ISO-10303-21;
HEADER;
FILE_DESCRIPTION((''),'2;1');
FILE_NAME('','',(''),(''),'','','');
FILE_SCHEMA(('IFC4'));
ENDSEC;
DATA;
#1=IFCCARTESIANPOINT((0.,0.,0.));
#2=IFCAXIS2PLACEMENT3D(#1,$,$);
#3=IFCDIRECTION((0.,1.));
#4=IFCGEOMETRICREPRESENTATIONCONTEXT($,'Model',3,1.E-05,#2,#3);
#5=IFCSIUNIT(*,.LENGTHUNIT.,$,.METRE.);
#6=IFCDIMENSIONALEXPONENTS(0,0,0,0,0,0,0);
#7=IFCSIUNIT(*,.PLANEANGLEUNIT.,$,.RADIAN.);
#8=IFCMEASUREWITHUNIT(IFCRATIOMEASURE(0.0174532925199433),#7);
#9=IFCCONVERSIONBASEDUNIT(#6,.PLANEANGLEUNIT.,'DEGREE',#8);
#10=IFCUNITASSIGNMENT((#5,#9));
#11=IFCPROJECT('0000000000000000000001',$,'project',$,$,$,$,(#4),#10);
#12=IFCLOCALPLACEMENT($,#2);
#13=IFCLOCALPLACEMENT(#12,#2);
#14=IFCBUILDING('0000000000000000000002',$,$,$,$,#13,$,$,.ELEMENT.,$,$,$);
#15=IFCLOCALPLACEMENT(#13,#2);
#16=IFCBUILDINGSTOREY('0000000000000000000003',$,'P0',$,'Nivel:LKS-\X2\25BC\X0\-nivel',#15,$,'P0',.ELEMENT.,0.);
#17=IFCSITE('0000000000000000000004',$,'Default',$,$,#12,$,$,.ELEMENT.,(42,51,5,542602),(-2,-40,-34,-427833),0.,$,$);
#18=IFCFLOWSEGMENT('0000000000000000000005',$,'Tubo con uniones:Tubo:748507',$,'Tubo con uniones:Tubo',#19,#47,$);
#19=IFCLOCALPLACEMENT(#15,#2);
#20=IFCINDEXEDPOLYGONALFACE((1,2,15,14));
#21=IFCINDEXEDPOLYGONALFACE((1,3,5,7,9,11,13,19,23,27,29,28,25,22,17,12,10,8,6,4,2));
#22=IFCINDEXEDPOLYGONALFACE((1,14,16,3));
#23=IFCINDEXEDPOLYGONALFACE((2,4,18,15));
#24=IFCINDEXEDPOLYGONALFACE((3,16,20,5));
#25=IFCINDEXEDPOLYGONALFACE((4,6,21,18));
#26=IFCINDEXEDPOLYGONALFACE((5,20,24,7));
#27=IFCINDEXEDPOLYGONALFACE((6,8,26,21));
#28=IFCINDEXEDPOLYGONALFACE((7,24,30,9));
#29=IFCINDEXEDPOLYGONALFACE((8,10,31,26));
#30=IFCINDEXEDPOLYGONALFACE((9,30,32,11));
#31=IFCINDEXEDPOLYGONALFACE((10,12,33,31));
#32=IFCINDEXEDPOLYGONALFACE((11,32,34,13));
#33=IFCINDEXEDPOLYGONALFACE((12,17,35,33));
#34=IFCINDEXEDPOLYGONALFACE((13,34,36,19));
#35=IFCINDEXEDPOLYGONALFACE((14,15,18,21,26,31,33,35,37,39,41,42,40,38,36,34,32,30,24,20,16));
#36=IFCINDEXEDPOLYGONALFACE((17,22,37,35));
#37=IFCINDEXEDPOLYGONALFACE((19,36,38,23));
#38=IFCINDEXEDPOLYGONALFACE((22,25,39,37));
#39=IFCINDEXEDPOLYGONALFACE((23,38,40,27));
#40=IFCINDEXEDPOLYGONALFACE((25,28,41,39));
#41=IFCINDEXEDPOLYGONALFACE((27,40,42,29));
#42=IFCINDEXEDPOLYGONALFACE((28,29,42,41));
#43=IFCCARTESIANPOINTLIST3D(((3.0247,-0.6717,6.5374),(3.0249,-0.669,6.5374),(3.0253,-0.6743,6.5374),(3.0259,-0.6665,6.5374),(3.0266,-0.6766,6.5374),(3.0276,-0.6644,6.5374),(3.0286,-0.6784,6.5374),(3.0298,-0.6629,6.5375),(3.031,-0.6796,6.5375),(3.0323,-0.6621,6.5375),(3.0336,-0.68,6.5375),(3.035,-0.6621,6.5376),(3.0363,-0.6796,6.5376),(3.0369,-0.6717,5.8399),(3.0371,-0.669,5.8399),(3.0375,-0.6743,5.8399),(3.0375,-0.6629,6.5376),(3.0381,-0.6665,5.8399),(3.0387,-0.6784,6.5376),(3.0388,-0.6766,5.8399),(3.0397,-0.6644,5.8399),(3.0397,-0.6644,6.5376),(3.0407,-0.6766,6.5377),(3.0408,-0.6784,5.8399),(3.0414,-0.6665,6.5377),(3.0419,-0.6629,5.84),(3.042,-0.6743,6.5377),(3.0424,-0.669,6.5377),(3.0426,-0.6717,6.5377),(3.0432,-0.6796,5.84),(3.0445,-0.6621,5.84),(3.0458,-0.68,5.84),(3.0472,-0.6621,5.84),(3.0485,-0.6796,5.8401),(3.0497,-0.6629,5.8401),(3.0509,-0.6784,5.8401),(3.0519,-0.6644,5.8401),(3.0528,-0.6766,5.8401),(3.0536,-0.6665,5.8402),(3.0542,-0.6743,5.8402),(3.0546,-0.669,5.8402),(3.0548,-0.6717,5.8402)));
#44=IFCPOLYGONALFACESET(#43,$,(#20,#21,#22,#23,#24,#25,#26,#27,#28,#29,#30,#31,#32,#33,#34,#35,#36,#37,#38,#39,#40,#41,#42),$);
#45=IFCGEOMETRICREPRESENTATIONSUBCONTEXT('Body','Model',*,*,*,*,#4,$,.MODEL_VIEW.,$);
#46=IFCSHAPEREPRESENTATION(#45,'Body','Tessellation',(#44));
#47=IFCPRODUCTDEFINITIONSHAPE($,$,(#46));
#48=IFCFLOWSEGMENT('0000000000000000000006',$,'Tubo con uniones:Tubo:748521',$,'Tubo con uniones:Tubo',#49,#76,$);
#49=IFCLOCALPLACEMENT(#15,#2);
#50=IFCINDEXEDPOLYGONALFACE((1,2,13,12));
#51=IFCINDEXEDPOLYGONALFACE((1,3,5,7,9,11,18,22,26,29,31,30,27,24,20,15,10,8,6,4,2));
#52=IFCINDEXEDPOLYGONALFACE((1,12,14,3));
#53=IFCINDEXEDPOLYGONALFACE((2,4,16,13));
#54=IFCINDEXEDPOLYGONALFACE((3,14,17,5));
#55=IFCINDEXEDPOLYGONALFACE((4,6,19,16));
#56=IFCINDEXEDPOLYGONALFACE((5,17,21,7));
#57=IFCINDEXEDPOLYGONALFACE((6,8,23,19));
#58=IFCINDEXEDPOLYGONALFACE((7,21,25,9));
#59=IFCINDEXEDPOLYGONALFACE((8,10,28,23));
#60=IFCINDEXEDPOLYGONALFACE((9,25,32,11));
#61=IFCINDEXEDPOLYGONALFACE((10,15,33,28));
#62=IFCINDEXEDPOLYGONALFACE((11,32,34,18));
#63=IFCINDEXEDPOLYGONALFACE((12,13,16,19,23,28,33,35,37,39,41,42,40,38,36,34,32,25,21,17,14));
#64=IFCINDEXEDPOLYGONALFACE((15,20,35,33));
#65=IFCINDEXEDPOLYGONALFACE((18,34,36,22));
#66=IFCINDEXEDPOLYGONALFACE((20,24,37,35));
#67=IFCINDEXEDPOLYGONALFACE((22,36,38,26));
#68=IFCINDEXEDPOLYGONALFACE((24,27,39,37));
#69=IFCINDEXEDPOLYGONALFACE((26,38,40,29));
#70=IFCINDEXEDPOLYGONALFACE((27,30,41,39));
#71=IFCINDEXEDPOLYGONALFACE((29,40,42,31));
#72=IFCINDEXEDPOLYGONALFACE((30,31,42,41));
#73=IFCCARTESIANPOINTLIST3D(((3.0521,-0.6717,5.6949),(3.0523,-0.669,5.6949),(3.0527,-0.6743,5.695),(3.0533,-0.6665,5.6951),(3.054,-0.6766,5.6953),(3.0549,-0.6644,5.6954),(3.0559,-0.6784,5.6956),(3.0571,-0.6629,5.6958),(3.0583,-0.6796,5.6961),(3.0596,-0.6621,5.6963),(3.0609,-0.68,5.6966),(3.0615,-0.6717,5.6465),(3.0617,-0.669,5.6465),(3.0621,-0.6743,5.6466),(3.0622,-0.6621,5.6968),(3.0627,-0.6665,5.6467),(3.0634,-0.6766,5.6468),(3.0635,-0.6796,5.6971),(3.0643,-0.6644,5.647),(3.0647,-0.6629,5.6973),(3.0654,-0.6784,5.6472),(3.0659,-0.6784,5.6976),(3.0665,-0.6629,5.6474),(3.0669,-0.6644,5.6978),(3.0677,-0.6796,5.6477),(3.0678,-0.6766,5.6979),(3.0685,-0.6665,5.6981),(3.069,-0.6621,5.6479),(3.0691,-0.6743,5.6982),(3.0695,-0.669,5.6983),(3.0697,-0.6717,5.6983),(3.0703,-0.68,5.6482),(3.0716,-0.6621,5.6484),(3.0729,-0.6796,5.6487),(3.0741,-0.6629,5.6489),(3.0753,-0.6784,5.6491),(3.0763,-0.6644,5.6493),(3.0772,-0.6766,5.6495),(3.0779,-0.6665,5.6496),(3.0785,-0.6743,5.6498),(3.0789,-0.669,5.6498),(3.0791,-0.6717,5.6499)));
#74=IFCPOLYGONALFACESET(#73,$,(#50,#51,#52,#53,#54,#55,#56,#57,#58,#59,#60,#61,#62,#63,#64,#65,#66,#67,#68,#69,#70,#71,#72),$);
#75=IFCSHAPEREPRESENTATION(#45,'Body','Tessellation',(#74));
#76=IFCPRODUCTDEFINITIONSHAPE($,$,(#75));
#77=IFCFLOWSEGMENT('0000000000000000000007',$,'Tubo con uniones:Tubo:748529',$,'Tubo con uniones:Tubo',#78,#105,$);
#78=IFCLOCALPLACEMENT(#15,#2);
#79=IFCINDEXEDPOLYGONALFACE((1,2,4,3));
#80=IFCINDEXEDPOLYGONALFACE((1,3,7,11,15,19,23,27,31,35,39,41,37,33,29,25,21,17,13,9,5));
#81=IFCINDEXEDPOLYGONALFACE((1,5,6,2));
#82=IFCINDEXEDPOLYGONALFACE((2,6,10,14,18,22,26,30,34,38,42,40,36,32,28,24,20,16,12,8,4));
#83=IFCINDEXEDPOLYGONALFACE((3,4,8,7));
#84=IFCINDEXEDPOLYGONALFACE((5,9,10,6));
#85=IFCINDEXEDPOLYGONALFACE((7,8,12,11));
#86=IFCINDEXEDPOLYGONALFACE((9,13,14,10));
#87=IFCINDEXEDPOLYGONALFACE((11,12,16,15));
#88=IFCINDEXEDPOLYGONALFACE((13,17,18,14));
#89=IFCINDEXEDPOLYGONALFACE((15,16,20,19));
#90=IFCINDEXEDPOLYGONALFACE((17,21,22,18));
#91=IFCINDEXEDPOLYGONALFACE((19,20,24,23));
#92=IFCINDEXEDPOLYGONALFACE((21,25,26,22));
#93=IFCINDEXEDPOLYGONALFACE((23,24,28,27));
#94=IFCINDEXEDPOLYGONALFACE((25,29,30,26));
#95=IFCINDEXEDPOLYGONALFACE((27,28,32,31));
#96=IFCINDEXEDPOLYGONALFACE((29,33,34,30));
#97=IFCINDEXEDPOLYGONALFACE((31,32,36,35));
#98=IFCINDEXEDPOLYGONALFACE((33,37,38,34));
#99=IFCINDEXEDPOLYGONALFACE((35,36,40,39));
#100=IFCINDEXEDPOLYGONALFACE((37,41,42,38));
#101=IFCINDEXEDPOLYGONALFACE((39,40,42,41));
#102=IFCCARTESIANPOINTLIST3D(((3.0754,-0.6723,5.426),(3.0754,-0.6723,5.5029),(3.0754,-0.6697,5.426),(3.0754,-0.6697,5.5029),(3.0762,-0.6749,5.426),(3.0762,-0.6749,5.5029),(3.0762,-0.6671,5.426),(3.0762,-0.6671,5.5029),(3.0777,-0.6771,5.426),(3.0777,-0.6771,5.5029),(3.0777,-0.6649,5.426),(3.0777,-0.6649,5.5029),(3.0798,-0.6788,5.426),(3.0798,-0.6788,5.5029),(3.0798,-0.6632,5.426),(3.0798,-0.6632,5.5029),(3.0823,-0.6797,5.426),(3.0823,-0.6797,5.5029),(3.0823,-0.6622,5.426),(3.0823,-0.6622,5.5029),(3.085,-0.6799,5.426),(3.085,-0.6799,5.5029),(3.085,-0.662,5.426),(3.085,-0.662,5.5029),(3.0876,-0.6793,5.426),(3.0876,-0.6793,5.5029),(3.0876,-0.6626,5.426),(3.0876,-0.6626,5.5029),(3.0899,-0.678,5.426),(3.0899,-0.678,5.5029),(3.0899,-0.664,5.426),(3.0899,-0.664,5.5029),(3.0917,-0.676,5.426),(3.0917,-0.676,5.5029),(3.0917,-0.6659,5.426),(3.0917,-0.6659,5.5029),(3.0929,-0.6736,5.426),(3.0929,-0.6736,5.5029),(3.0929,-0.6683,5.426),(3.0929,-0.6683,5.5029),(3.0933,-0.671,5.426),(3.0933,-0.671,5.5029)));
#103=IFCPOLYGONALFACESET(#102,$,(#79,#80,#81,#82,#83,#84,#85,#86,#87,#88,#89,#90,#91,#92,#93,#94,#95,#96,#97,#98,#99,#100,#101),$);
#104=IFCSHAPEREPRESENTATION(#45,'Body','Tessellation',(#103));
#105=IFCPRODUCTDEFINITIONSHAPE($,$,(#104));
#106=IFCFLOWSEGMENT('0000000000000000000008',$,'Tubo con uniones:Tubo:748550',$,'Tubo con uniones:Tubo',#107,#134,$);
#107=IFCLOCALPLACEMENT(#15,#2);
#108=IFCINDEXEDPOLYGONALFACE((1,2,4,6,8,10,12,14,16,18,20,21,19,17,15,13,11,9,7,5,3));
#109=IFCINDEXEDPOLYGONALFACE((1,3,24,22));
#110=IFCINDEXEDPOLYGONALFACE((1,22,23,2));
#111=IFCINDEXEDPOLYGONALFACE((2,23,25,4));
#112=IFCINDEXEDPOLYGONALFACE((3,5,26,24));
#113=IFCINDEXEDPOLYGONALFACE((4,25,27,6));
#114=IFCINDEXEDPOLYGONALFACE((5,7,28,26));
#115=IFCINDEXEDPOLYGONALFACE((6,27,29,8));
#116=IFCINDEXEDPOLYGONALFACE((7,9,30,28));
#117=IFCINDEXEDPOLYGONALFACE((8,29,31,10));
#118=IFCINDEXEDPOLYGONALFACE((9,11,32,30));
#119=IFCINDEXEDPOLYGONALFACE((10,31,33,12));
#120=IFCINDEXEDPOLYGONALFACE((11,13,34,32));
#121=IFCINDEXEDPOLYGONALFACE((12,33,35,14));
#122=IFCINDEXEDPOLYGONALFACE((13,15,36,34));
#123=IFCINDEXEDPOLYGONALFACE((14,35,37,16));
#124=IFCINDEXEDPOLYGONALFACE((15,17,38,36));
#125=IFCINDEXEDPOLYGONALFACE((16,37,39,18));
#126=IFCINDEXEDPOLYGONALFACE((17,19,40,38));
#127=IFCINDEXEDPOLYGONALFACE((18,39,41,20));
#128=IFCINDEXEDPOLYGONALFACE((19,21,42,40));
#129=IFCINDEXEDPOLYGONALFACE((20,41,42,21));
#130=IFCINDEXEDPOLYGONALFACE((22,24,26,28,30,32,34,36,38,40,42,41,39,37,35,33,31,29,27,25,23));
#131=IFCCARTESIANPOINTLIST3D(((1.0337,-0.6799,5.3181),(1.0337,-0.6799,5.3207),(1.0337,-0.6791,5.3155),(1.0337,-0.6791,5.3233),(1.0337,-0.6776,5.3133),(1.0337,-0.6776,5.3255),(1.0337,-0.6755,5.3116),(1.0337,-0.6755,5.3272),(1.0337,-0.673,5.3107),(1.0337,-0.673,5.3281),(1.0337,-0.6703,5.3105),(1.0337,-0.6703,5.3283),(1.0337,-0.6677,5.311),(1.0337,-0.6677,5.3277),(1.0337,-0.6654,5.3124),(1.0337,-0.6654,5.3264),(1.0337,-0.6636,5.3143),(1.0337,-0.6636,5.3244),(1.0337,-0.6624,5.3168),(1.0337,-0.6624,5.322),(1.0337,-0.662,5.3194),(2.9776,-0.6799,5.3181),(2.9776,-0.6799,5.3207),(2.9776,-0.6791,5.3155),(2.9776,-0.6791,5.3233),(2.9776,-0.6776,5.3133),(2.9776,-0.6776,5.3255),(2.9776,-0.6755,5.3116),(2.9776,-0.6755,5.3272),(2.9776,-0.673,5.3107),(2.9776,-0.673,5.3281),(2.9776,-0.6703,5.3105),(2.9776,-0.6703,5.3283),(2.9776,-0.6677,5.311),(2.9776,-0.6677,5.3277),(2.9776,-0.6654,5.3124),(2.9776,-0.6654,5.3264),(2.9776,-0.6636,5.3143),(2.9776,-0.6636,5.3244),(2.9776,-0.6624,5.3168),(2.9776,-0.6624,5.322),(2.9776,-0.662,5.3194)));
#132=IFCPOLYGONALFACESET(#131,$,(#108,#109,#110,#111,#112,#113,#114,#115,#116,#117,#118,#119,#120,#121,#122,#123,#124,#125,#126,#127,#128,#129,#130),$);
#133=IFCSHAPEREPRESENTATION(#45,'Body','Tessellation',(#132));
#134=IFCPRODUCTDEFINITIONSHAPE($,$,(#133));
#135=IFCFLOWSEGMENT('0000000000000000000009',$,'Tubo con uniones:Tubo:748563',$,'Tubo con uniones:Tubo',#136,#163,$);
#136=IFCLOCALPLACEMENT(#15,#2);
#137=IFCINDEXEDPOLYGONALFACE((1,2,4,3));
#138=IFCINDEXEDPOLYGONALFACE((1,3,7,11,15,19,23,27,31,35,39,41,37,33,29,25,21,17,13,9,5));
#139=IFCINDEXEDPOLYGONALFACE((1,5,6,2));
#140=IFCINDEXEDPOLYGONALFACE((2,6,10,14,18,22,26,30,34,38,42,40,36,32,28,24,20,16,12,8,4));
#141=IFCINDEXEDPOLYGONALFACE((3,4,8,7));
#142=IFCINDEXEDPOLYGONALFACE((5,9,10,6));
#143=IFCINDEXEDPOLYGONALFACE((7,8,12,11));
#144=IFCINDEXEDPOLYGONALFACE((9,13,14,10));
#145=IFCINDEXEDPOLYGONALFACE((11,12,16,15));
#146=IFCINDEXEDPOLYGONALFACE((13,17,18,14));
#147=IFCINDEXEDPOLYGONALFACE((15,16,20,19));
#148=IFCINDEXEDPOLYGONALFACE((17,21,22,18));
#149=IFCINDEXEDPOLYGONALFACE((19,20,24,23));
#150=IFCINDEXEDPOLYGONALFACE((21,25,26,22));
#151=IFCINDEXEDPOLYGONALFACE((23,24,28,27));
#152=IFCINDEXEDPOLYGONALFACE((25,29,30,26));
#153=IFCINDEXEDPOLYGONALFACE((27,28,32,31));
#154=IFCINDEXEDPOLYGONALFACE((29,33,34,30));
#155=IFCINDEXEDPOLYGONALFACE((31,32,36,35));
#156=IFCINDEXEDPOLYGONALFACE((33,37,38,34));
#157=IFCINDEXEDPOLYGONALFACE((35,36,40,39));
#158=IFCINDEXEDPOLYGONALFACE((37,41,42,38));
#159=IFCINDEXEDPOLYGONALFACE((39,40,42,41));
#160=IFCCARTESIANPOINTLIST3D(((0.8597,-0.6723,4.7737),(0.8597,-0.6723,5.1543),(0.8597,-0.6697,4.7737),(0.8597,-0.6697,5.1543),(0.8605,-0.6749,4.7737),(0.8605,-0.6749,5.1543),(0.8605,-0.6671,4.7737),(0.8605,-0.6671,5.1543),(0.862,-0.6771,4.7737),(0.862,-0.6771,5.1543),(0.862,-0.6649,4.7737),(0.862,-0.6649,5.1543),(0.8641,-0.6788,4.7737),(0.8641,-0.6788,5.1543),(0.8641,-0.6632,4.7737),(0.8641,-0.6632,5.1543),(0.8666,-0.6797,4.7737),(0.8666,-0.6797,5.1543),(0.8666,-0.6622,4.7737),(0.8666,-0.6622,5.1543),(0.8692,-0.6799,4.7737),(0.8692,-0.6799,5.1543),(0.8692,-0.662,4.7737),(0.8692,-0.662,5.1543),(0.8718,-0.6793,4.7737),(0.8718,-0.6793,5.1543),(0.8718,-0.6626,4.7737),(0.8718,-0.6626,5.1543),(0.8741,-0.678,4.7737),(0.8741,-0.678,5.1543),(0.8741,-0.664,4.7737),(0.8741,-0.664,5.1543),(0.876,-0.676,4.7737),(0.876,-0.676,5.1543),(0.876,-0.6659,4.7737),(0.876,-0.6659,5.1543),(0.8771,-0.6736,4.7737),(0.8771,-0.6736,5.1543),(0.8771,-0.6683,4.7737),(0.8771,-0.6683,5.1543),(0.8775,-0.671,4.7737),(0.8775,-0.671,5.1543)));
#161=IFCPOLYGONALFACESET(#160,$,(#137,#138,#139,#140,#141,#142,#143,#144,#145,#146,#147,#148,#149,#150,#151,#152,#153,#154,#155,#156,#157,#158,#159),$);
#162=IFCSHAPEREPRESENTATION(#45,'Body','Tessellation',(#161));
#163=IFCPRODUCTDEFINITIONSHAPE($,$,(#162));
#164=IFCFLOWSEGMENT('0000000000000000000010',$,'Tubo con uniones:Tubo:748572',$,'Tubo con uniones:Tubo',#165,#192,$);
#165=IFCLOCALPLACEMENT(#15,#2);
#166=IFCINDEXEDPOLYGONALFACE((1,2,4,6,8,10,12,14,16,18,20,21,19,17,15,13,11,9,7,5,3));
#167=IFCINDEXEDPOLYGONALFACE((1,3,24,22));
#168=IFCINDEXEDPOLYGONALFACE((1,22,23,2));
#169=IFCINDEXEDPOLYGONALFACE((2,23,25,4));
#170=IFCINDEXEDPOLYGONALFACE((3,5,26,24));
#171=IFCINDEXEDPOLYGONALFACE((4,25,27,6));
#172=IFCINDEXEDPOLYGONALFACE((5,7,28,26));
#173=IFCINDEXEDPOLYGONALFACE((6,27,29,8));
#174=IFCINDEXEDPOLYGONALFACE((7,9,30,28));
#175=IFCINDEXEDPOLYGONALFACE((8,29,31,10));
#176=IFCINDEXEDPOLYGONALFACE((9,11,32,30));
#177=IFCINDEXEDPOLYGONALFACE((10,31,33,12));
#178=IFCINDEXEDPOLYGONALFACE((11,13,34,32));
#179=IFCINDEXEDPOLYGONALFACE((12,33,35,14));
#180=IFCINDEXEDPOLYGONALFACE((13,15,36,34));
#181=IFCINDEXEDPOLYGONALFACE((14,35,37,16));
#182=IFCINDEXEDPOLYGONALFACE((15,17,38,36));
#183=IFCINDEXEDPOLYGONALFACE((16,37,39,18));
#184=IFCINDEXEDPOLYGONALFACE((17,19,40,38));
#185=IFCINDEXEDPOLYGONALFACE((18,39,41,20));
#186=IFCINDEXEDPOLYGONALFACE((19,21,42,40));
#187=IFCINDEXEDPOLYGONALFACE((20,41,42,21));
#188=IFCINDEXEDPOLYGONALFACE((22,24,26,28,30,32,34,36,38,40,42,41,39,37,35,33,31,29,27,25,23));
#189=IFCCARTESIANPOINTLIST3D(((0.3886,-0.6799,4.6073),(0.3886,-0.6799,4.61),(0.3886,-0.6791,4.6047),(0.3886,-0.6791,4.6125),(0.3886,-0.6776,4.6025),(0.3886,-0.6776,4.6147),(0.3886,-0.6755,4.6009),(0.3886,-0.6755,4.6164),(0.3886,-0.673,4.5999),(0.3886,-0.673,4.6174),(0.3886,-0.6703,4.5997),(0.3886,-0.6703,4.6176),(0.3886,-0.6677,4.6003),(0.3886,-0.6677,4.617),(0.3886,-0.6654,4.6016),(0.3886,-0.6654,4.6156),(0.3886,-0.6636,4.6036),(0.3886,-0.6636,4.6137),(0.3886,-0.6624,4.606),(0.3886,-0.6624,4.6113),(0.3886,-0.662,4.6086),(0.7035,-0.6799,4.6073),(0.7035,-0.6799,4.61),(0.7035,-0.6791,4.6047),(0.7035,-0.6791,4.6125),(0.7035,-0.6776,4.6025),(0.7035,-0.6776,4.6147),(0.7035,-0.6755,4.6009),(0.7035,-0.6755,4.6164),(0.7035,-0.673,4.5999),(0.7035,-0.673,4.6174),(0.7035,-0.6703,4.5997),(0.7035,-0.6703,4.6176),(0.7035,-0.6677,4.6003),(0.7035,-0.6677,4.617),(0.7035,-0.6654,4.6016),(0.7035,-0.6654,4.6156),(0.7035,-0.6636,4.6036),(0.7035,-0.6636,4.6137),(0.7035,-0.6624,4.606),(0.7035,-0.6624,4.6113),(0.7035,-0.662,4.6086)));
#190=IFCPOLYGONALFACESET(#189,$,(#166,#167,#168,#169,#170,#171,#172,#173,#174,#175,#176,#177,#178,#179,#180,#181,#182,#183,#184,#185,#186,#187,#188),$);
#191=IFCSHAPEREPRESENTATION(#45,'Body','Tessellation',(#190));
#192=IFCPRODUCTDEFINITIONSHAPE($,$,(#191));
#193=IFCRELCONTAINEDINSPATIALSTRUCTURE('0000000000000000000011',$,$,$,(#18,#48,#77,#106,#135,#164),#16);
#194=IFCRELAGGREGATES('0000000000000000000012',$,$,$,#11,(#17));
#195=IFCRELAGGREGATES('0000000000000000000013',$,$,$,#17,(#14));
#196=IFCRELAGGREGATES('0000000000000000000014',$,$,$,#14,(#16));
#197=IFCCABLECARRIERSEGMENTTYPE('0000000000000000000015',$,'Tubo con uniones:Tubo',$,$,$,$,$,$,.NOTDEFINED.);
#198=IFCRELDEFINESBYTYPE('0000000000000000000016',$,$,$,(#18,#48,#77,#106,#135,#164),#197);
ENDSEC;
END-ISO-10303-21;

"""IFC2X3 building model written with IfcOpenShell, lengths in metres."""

from ifc_helpers import new_model, entity, si_unit, converted_unit, direction, frame, frame_2d, origin, origin_2d_with_axis, place, context, subcontext, project, spatial, circle, extrude, type_object, element, save


model = new_model("IFC2X3")

# Units and contexts
model_context = context("Model", 3, precision=1e-05, world=origin(), true_north=direction((0.0, 1.0)))
body_context = subcontext(model_context, "Body", "Model", "MODEL_VIEW")
ifc_project = project(units=[si_unit("LENGTHUNIT", "METRE"), converted_unit("PLANEANGLEUNIT", "DEGREE", entity("IfcRatioMeasure", 0.0174532925199433), si_unit("PLANEANGLEUNIT", "RADIAN"), dimensions=[0, 0, 0, 0, 0, 0, 0])], contexts=[model_context])

# Site, building, storey
site_placement = place(None, origin())
site = spatial("IfcSite", under=ifc_project, at=site_placement, Name="Default", CompositionType="ELEMENT", RefLatitude=(42, 51, 5, 542602), RefLongitude=(-2, -40, -34, -427833), RefElevation=0.0)
building_placement = place(site_placement, origin())
building = spatial("IfcBuilding", under=site, at=building_placement, CompositionType="ELEMENT")
storey_placement = place(building_placement, origin())
storey = spatial("IfcBuildingStorey", under=building, at=storey_placement, Name="P0", ObjectType="Nivel:LKS-▼-nivel", LongName="P0", CompositionType="ELEMENT", Elevation=0.0)

# Flow segments
cable_carrier_segment_type = type_object("IfcCableCarrierSegmentType", Name="Tubo con uniones:Tubo", PredefinedType="NOTDEFINED")
flow_segment_1_placement = place(storey_placement, origin())
element("IfcFlowSegment", 1, at=flow_segment_1_placement, inside=storey, type_object=cable_carrier_segment_type, Name="Tubo con uniones:Tubo:748507", ObjectType="Tubo con uniones:Tubo", context=body_context, shape_type="SweptSolid", body=[
    extrude(circle(Radius=0.009, at=frame_2d((0.0, 0.0), x_axis=(1.0, 0.0))), frame((3.0458, -0.671, 5.84), z_axis=(-0.017452, 0.0, 0.999848), x_axis=(0.0, -1.0, 0.0)), (0.0, 0.0, 1.0), 0.6976),
])
flow_segment_2_placement = place(storey_placement, origin())
element("IfcFlowSegment", 2, at=flow_segment_2_placement, inside=storey, type_object=cable_carrier_segment_type, Name="Tubo con uniones:Tubo:748521", ObjectType="Tubo con uniones:Tubo", context=body_context, shape_type="SweptSolid", body=[
    extrude(circle(Radius=0.009, at=origin_2d_with_axis()), frame((3.0609, -0.671, 5.6966), z_axis=(0.190809, 0.0, -0.981627), x_axis=(0.0, -1.0, 0.0)), (0.0, 0.0, 1.0), 0.0493),
])
flow_segment_3_placement = place(storey_placement, origin())
element("IfcFlowSegment", 3, at=flow_segment_3_placement, inside=storey, type_object=cable_carrier_segment_type, Name="Tubo con uniones:Tubo:748529", ObjectType="Tubo con uniones:Tubo", context=body_context, shape_type="SweptSolid", body=[
    extrude(circle(Radius=0.009, at=frame_2d((0.0, 0.0), x_axis=(1.0, 0.0))), frame((3.0843, -0.671, 5.426)), (0.0, 0.0, 1.0), 0.0769),
])
flow_segment_4_placement = place(storey_placement, origin())
element("IfcFlowSegment", 4, at=flow_segment_4_placement, inside=storey, type_object=cable_carrier_segment_type, Name="Tubo con uniones:Tubo:748550", ObjectType="Tubo con uniones:Tubo", context=body_context, shape_type="SweptSolid", body=[
    extrude(circle(Radius=0.009, at=frame_2d((0.0, 0.0), x_axis=(1.0, 0.0))), frame((1.0337, -0.671, 5.3194), z_axis=(1.0, 0.0, 0.0), x_axis=(0.0, 1.0, 0.0)), (0.0, 0.0, 1.0), 1.944),
])
flow_segment_5_placement = place(storey_placement, origin())
element("IfcFlowSegment", 5, at=flow_segment_5_placement, inside=storey, type_object=cable_carrier_segment_type, Name="Tubo con uniones:Tubo:748563", ObjectType="Tubo con uniones:Tubo", context=body_context, shape_type="SweptSolid", body=[
    extrude(circle(Radius=0.009, at=frame_2d((0.0, 0.0), x_axis=(1.0, 0.0))), frame((0.8686, -0.671, 4.7737)), (0.0, 0.0, 1.0), 0.3806),
])
flow_segment_6_placement = place(storey_placement, origin())
element("IfcFlowSegment", 6, at=flow_segment_6_placement, inside=storey, type_object=cable_carrier_segment_type, Name="Tubo con uniones:Tubo:748572", ObjectType="Tubo con uniones:Tubo", context=body_context, shape_type="SweptSolid", body=[
    extrude(circle(Radius=0.009, at=frame_2d((0.0, 0.0), x_axis=(1.0, 0.0))), frame((0.3886, -0.671, 4.6086), z_axis=(1.0, 0.0, 0.0), x_axis=(0.0, 1.0, 0.0)), (0.0, 0.0, 1.0), 0.3149),
])

save(model, "model.ifc")
